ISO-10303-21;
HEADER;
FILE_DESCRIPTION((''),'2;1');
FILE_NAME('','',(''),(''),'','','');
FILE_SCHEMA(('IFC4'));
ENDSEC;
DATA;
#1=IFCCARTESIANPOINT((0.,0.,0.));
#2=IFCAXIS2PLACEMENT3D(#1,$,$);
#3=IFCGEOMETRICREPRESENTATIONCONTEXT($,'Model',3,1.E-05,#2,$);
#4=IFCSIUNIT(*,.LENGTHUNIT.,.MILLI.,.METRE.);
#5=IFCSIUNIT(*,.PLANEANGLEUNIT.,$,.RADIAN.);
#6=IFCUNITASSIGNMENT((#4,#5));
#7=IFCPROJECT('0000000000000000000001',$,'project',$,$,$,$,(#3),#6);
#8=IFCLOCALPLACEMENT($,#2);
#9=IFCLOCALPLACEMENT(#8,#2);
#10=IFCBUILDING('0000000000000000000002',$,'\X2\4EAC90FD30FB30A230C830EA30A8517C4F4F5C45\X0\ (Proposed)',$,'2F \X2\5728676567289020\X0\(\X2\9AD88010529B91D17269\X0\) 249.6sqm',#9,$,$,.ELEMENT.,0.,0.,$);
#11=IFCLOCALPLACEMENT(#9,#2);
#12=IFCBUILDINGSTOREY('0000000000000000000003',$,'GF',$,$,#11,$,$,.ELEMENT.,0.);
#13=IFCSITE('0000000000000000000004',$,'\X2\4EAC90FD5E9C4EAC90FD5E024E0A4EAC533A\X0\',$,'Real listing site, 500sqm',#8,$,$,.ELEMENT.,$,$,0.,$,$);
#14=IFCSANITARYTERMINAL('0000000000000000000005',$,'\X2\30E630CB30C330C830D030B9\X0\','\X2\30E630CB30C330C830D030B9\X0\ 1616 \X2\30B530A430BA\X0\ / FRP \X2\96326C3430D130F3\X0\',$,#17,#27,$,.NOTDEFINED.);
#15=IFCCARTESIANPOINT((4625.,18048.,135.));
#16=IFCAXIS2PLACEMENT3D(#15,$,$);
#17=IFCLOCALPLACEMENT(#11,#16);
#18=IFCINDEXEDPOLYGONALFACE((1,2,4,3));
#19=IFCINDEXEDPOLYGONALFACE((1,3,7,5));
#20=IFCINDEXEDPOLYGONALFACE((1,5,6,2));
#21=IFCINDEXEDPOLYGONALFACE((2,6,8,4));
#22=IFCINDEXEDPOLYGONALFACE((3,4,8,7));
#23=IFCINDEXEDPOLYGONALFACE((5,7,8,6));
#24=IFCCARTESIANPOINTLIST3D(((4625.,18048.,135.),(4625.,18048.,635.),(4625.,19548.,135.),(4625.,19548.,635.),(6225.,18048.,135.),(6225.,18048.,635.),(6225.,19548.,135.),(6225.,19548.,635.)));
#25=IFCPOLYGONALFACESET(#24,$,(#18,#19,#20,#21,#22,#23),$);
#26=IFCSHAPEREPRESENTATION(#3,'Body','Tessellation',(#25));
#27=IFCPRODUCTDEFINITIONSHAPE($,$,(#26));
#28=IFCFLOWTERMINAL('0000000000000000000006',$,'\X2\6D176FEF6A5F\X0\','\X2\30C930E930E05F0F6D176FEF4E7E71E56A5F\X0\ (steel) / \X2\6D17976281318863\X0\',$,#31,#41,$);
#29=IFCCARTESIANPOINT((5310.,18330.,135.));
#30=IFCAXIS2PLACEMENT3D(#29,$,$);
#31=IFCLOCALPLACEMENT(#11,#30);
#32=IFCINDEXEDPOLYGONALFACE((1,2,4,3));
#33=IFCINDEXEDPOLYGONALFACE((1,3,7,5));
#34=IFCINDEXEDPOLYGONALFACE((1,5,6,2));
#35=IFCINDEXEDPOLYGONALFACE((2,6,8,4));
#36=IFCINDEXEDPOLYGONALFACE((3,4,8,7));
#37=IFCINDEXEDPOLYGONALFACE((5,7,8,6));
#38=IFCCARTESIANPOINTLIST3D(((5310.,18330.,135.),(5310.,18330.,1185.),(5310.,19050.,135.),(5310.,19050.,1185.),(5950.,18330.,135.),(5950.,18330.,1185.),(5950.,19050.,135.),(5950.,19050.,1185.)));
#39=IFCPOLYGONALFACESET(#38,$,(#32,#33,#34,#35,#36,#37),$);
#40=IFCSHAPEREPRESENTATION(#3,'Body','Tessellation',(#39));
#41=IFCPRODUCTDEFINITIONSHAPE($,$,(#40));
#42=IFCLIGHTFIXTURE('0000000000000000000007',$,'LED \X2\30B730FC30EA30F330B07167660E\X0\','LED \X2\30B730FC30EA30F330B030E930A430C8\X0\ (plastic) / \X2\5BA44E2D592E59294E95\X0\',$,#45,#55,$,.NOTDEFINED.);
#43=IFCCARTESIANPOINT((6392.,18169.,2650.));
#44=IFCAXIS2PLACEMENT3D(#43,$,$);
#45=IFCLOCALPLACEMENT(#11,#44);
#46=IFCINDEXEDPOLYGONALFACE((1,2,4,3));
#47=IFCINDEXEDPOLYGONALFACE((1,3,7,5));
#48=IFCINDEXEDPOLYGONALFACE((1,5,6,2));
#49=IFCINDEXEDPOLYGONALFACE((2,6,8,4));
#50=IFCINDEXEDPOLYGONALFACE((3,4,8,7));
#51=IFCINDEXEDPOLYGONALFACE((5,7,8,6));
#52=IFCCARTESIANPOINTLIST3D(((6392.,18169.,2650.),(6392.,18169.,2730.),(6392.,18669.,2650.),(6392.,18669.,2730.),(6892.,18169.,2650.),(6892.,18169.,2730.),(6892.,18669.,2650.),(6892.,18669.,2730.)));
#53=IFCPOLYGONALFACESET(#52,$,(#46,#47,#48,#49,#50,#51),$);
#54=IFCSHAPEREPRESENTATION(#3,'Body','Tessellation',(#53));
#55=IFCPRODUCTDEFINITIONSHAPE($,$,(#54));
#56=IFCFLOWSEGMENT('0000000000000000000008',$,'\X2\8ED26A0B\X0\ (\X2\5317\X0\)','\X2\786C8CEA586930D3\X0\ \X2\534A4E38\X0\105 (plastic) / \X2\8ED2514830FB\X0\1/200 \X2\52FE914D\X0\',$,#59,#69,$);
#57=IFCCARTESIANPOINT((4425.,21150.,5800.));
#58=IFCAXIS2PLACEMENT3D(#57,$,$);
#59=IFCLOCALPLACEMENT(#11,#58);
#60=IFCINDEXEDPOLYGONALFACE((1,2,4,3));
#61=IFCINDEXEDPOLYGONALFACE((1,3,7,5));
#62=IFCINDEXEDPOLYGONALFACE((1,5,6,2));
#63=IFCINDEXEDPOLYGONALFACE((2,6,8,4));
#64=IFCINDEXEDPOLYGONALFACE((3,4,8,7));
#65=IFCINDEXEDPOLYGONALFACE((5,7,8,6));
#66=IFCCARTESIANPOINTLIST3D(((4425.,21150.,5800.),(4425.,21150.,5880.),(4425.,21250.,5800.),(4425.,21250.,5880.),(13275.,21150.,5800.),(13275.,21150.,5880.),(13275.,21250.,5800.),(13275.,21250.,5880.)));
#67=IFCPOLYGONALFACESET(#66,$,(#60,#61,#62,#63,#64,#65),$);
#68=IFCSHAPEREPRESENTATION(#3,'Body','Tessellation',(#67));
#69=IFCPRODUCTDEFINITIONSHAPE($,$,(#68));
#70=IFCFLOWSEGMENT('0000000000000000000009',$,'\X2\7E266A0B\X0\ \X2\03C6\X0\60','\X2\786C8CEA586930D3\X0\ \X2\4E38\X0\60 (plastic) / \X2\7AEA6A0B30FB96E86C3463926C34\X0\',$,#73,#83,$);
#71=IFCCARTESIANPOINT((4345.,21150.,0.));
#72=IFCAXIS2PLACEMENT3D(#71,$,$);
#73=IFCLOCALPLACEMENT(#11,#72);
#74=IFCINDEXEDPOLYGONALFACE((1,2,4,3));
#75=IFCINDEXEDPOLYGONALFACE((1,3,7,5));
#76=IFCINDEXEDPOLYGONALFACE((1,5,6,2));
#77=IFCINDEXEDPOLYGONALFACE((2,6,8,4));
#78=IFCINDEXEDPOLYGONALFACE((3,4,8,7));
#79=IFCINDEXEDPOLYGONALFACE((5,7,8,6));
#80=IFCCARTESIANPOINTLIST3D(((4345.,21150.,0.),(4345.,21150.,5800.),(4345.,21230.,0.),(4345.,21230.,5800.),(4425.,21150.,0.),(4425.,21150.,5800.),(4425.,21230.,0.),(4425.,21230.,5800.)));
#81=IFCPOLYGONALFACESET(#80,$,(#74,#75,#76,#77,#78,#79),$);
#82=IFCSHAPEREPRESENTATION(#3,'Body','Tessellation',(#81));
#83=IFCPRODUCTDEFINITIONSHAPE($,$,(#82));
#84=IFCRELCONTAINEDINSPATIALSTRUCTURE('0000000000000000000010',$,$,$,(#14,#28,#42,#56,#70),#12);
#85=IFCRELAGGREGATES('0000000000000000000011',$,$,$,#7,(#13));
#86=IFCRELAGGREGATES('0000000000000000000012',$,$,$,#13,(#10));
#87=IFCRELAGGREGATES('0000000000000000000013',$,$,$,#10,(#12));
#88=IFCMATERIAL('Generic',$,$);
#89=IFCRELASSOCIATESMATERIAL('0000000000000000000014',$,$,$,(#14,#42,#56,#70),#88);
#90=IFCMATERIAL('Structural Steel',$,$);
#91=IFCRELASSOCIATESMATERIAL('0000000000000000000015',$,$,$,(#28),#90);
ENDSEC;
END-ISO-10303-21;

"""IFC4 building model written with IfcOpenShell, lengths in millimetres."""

from ifc_helpers import new_model, si_unit, frame, frame_2d, origin, place, context, project, spatial, rectangle, extrude, material, element, save


model = new_model("IFC4")

# Units and contexts
model_context = context("Model", 3, precision=1e-05, world=origin())
ifc_project = project(units=[si_unit("LENGTHUNIT", "METRE", prefix="MILLI"), si_unit("PLANEANGLEUNIT", "RADIAN")], contexts=[model_context])

# Site, building, storey
site_placement = place(None, origin())
site = spatial("IfcSite", under=ifc_project, at=site_placement, Name="京都府京都市上京区", ObjectType="Real listing site, 500sqm", CompositionType="ELEMENT", RefElevation=0.0)
building_placement = place(site_placement, origin())
building = spatial("IfcBuilding", under=site, at=building_placement, Name="京都・アトリエ兼住居 (Proposed)", ObjectType="2F 在来木造(高耐力金物) 249.6sqm", CompositionType="ELEMENT", ElevationOfRefHeight=0.0, ElevationOfTerrain=0.0)
storey_placement = place(building_placement, origin())
storey = spatial("IfcBuildingStorey", under=building, at=storey_placement, Name="GF", CompositionType="ELEMENT", Elevation=0.0)

# Sanitary terminal
ifc_material_1 = material(Name="Generic")
sanitary_terminal_placement = place(storey_placement, frame((4625.0, 18048.0, 135.0)))
element("IfcSanitaryTerminal", 1, at=sanitary_terminal_placement, inside=storey, material=ifc_material_1, Name="ユニットバス", Description="ユニットバス 1616 サイズ / FRP 防水パン", PredefinedType="NOTDEFINED", context=model_context, shape_type="SweptSolid", body=[
    extrude(rectangle(XDim=1600.0, YDim=1500.0, at=frame_2d((800.0, 750.0))), frame((4625.0, 18048.0, 135.0)), (0.0, 0.0, 1.0), 500.0),
])

# Flow terminal
ifc_material_2 = material(Name="Structural Steel")
flow_terminal_placement = place(storey_placement, frame((5310.0, 18330.0, 135.0)))
element("IfcFlowTerminal", 2, at=flow_terminal_placement, inside=storey, material=ifc_material_2, Name="洗濯機", Description="ドラム式洗濯乾燥機 (steel) / 洗面脱衣", context=model_context, shape_type="SweptSolid", body=[
    extrude(rectangle(XDim=640.0, YDim=720.0, at=frame_2d((320.0, 360.0))), frame((5310.0, 18330.0, 135.0)), (0.0, 0.0, 1.0), 1050.0),
])

# Light fixture
light_fixture_placement = place(storey_placement, frame((6392.0, 18169.0, 2650.0)))
element("IfcLightFixture", 3, at=light_fixture_placement, inside=storey, material=ifc_material_1, Name="LED シーリング照明", Description="LED シーリングライト (plastic) / 室中央天井", PredefinedType="NOTDEFINED", context=model_context, shape_type="SweptSolid", body=[
    extrude(rectangle(XDim=500.0, YDim=500.0, at=frame_2d((250.0, 250.0))), frame((6392.0, 18169.0, 2650.0)), (0.0, 0.0, 1.0), 80.0),
])

# Flow segments
flow_segment_1_placement = place(storey_placement, frame((4425.0, 21150.0, 5800.0)))
element("IfcFlowSegment", 4, at=flow_segment_1_placement, inside=storey, material=ifc_material_1, Name="軒樋 (北)", Description="硬質塩ビ 半丸105 (plastic) / 軒先・1/200 勾配", context=model_context, shape_type="SweptSolid", body=[
    extrude(rectangle(XDim=8850.0, YDim=100.0, at=frame_2d((4425.0, 50.0))), frame((4425.0, 21150.0, 5800.0)), (0.0, 0.0, 1.0), 80.0),
])
flow_segment_2_placement = place(storey_placement, frame((4345.0, 21150.0, 0.0)))
element("IfcFlowSegment", 5, at=flow_segment_2_placement, inside=storey, material=ifc_material_1, Name="縦樋 φ60", Description="硬質塩ビ 丸60 (plastic) / 竪樋・雨水排水", context=model_context, shape_type="SweptSolid", body=[
    extrude(rectangle(XDim=80.0, YDim=80.0, at=frame_2d((40.0, 40.0))), frame((4345.0, 21150.0, 0.0)), (0.0, 0.0, 1.0), 5800.0),
])

save(model, "model.ifc")
